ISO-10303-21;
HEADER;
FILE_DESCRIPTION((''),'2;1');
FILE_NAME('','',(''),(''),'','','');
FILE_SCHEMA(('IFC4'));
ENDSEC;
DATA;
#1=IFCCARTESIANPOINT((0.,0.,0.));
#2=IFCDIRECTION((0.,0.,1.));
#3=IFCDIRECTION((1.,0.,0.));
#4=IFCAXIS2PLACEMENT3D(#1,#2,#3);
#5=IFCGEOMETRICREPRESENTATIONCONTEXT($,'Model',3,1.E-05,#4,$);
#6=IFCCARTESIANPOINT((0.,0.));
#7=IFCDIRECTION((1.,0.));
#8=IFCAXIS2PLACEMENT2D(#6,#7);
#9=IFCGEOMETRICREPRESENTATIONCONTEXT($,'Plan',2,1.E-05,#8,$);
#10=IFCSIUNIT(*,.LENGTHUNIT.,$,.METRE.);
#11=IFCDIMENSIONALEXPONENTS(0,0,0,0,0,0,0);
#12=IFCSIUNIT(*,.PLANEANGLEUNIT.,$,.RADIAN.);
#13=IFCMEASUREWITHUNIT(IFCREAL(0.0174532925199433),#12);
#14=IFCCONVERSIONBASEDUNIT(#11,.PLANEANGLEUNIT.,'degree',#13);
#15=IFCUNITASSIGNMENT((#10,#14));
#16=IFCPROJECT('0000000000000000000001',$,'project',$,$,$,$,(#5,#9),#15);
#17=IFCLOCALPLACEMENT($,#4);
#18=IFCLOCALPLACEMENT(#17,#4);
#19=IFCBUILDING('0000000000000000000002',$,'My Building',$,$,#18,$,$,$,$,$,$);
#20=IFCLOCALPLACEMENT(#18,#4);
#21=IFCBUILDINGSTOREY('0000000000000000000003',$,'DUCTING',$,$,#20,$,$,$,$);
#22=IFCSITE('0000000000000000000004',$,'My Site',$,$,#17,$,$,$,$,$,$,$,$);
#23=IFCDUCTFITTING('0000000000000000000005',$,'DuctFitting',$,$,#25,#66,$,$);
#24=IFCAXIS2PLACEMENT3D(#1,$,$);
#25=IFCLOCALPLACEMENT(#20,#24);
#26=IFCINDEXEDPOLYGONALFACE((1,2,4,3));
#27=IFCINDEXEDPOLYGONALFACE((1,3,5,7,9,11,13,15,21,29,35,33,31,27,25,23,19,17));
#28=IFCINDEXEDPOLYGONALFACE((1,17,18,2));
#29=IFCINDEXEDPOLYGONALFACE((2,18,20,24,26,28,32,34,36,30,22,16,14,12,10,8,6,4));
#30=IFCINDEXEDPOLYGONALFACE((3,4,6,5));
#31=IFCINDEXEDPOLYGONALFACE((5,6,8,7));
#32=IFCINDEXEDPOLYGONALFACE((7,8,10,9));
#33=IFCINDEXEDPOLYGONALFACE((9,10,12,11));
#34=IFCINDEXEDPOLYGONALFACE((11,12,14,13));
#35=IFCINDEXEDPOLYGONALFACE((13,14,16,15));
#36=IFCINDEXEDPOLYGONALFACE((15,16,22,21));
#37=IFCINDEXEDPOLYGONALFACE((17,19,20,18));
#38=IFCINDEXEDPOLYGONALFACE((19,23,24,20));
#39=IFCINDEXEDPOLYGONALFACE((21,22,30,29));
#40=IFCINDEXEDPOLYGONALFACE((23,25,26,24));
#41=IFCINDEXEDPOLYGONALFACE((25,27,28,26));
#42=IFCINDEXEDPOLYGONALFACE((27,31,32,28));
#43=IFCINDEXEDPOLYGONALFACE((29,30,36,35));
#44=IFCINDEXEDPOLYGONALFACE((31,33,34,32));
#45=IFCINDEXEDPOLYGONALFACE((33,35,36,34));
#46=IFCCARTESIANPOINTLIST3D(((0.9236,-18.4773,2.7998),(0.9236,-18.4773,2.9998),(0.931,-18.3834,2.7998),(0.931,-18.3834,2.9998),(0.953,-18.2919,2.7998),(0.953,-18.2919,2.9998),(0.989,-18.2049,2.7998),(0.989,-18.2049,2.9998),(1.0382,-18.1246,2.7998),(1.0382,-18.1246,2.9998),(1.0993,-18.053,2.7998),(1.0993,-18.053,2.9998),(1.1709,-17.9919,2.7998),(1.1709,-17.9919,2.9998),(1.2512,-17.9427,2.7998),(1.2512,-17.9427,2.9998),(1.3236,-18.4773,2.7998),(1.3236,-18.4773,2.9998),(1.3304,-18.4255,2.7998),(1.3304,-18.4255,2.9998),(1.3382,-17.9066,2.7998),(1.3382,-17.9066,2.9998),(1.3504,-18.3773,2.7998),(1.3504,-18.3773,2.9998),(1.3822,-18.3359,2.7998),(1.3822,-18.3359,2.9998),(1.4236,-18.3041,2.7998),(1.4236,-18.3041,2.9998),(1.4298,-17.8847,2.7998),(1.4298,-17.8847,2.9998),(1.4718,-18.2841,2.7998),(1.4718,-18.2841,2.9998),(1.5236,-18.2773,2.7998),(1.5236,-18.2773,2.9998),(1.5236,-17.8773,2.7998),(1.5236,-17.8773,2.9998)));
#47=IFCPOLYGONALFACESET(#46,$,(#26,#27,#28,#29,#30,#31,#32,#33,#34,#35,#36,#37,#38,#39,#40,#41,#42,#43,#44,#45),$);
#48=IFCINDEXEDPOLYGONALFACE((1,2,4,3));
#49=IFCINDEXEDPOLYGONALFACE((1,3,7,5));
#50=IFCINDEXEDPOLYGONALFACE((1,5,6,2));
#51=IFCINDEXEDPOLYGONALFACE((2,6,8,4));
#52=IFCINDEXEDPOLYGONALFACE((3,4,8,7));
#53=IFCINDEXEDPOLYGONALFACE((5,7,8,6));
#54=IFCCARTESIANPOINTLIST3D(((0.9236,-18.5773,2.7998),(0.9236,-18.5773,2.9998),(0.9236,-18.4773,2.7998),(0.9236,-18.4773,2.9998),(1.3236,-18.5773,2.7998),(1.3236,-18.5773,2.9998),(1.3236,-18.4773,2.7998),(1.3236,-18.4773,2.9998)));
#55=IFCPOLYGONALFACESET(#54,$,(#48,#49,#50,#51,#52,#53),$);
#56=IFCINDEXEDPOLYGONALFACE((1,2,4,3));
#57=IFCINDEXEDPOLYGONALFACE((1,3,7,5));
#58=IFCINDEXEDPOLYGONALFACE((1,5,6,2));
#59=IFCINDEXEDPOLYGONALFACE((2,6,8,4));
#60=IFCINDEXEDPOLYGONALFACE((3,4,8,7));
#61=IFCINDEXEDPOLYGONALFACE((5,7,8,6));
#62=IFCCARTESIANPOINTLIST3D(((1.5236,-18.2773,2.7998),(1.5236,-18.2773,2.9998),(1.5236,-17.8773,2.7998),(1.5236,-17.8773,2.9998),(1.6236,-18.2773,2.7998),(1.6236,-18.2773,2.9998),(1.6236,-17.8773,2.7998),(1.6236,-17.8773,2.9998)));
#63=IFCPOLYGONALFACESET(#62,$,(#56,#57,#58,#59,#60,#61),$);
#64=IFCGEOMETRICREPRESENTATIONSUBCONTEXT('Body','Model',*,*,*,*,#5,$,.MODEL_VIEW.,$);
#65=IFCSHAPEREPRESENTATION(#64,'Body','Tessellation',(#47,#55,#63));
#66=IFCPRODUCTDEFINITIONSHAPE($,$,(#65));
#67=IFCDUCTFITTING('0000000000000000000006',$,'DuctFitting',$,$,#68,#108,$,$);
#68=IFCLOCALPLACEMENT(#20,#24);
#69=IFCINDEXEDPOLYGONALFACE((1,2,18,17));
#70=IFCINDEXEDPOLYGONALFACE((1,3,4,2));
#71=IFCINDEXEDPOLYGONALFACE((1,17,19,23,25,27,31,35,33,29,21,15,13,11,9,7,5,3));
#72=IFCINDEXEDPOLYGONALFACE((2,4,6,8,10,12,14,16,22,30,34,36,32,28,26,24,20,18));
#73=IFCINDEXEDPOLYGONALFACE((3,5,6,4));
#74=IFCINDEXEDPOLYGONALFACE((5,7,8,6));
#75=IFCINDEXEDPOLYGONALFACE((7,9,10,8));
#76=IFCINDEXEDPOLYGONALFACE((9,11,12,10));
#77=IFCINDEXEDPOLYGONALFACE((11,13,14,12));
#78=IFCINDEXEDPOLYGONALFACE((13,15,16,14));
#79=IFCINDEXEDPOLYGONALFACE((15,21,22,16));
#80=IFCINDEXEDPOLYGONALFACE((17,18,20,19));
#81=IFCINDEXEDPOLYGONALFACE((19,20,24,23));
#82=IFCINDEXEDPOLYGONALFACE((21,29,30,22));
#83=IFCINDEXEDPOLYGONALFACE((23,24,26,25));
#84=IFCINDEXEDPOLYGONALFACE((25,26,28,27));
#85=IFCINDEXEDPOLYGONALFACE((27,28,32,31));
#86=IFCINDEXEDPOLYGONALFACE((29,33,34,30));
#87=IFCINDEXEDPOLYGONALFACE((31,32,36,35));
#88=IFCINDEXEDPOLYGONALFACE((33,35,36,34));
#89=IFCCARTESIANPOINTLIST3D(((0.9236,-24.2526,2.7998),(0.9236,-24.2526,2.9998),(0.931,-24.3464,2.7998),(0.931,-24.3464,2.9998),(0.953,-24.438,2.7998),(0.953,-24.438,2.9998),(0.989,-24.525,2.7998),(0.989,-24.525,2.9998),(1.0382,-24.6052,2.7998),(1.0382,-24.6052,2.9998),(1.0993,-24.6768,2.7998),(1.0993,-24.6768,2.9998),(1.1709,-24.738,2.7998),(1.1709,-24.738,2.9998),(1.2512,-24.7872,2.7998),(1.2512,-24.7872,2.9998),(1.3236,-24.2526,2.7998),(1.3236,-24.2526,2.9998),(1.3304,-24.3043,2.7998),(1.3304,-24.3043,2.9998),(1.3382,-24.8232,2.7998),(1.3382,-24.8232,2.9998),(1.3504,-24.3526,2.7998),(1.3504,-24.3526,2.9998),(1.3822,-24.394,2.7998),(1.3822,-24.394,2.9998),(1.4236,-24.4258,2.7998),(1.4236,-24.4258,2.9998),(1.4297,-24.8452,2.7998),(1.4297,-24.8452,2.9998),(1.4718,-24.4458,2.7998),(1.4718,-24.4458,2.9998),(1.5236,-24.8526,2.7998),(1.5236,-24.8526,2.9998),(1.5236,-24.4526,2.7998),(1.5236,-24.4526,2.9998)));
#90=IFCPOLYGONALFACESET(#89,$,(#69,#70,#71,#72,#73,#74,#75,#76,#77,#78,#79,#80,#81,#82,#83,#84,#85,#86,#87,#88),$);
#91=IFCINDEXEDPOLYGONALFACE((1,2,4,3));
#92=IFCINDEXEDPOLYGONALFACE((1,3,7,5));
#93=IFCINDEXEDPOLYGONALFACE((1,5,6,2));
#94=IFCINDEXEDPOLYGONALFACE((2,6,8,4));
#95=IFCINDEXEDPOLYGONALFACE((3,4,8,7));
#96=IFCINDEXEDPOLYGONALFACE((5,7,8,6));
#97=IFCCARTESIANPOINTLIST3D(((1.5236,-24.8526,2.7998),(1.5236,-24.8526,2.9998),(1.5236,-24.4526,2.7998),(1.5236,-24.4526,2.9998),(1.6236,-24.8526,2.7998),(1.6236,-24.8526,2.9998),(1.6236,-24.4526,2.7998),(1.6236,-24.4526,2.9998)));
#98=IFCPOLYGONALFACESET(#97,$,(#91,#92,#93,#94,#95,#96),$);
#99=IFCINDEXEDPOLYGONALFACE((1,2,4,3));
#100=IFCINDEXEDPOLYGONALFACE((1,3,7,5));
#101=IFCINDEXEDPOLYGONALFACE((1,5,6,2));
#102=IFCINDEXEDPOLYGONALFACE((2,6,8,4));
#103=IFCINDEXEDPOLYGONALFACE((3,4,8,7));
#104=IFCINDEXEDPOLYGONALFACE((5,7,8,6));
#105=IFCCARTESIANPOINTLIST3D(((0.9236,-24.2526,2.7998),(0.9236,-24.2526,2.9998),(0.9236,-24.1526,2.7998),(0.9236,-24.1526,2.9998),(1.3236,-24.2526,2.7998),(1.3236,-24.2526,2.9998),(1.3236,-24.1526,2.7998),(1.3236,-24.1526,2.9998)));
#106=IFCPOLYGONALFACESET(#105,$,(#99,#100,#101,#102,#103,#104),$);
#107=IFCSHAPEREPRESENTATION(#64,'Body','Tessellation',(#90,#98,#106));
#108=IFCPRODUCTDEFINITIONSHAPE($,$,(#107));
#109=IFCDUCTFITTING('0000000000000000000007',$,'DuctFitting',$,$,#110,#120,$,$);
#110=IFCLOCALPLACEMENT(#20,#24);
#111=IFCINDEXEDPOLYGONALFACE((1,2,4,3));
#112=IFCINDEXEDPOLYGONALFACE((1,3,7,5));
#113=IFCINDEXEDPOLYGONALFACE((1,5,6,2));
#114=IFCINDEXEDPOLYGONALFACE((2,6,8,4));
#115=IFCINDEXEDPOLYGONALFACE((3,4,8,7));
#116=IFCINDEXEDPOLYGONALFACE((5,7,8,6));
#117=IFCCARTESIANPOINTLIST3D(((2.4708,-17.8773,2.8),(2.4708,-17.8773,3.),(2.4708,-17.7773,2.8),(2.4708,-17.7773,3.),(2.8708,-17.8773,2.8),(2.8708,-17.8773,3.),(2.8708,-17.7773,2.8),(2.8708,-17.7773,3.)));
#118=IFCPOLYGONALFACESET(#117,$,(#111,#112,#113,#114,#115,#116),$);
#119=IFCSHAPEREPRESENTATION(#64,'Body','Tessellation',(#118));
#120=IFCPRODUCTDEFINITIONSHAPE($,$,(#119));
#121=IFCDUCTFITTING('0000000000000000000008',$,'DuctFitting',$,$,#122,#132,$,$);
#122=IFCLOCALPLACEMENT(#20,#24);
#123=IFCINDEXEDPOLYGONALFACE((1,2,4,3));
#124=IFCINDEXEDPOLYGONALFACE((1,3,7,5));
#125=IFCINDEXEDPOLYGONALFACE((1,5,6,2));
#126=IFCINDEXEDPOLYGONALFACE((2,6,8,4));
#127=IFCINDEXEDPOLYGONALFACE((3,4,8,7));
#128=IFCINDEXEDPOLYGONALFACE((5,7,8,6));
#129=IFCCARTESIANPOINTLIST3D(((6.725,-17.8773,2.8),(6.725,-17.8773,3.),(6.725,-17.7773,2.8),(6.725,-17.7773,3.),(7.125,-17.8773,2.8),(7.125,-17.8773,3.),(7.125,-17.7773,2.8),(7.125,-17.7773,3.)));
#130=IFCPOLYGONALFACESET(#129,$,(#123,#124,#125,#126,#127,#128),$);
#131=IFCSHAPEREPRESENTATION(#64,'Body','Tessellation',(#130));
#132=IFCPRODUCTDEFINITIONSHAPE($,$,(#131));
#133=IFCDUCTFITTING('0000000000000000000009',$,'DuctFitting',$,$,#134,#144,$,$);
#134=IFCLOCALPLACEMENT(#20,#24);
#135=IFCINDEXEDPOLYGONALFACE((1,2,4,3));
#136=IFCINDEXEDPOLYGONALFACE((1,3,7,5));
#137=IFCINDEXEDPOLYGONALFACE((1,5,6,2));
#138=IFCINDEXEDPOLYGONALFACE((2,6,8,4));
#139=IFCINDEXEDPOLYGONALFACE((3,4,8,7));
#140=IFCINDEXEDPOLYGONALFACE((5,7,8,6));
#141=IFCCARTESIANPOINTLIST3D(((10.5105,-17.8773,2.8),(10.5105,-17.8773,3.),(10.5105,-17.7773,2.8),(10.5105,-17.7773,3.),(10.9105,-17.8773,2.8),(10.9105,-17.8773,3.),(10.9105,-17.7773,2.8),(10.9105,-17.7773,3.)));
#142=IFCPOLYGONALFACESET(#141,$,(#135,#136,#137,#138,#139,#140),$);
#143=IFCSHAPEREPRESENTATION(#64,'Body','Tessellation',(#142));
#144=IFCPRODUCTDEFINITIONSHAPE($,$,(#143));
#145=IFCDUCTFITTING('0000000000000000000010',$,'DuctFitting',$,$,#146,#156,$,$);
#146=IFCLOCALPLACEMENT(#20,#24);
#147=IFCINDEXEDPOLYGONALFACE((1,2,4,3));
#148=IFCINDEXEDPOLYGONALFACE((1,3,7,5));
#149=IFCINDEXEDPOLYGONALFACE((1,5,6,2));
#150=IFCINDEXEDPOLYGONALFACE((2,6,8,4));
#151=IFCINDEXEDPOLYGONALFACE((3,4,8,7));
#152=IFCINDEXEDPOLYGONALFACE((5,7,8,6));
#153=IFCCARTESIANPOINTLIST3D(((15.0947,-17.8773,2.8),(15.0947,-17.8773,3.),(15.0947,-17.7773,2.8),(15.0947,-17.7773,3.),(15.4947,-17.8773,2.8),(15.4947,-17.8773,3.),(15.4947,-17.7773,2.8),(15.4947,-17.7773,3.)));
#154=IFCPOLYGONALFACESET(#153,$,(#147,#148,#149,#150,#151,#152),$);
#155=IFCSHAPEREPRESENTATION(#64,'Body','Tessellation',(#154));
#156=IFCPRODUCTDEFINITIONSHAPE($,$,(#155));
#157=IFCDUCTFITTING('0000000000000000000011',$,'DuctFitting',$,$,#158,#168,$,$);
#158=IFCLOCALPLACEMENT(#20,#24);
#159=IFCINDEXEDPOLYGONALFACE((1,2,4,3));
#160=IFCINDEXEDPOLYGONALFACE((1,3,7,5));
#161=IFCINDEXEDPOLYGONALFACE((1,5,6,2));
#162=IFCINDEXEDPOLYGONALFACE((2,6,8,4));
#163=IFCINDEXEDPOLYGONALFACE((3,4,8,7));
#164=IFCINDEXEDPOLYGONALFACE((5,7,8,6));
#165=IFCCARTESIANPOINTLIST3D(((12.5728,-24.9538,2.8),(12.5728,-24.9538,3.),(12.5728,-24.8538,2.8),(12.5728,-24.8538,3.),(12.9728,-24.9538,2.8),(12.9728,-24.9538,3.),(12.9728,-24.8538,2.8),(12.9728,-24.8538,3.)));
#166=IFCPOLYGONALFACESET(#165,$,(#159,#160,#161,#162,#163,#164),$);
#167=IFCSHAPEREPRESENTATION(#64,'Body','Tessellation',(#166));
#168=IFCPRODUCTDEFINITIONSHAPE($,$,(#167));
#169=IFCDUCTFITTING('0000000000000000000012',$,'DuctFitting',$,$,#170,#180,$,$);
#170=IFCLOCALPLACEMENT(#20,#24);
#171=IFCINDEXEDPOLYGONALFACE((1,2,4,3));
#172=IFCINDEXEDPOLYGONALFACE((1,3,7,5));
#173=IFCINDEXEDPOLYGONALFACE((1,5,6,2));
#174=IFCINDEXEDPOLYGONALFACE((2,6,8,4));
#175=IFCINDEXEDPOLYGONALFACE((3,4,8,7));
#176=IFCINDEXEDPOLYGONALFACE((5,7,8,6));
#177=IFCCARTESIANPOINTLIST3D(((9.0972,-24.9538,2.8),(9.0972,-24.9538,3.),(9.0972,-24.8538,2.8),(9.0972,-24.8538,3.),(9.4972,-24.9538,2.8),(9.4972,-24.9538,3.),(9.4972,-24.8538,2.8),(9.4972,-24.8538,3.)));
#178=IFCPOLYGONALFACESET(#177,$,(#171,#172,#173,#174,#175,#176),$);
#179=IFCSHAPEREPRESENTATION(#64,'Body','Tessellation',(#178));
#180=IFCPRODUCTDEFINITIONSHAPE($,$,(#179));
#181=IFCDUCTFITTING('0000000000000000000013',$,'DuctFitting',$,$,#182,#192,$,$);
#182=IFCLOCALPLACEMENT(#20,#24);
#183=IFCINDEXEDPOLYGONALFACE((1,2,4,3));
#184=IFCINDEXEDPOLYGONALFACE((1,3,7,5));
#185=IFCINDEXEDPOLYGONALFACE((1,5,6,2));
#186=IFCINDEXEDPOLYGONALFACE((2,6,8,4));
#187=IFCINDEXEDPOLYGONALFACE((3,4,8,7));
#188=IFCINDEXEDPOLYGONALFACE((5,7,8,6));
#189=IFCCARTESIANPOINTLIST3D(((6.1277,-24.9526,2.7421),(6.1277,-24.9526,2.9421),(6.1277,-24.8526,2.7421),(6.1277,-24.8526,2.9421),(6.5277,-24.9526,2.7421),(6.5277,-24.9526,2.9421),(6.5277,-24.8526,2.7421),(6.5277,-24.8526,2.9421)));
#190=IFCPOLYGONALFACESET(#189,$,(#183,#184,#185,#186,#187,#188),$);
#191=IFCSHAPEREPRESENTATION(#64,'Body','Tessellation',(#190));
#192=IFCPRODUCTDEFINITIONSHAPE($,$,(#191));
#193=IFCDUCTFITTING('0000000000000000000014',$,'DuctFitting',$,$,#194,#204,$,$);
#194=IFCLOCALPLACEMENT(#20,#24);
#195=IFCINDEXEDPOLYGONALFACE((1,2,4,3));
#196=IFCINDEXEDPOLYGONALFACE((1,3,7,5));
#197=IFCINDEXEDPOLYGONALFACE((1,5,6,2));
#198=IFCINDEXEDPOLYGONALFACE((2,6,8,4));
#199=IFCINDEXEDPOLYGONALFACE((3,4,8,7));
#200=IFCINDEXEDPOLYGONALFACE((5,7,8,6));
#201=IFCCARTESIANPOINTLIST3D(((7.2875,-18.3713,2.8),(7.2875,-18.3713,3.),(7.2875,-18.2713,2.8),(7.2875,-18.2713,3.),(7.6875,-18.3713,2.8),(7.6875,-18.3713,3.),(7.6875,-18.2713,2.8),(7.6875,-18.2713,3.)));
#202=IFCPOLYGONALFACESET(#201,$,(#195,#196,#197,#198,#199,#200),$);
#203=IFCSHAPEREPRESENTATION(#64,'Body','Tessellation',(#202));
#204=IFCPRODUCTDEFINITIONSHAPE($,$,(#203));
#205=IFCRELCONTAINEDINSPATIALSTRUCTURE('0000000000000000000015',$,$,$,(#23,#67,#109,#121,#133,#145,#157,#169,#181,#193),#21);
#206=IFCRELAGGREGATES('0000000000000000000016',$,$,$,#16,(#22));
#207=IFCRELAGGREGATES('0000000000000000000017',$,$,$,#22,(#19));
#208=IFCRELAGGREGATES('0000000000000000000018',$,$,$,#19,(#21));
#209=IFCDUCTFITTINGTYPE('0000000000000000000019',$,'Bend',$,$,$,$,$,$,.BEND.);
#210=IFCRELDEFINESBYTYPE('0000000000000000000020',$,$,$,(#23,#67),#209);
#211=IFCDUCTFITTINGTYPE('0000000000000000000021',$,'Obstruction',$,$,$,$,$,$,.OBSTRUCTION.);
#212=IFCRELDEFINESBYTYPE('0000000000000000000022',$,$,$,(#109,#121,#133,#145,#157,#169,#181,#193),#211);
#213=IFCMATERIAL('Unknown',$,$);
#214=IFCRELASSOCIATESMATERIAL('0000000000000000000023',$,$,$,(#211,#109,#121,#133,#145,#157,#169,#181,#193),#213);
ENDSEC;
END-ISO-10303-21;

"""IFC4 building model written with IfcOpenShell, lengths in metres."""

from ifc_helpers import new_model, entity, si_unit, converted_unit, frame, origin_with_axes, origin_2d_with_axis, place, context, subcontext, project, spatial, line, arc, indexed_curve, rectangle, outline, extrude, source, transform, mapped, material, material_profile, profile_set, profile_usage, type_object, type_shapes, element, save


model = new_model("IFC4")

# Units and contexts
model_context = context("Model", 3, precision=1e-05, world=origin_with_axes())
plan_context = context("Plan", 2, precision=1e-05, world=origin_2d_with_axis())
body_context = subcontext(model_context, "Body", "Model", "MODEL_VIEW")
ifc_project = project(units=[si_unit("LENGTHUNIT", "METRE"), converted_unit("PLANEANGLEUNIT", "degree", entity("IfcReal", 0.0174532925199433), si_unit("PLANEANGLEUNIT", "RADIAN"), dimensions=[0, 0, 0, 0, 0, 0, 0])], contexts=[model_context, plan_context])

# Site, building, storey
site_placement = place(None, origin_with_axes())
site = spatial("IfcSite", under=ifc_project, at=site_placement, Name="My Site")
building_placement = place(site_placement, origin_with_axes())
building = spatial("IfcBuilding", under=site, at=building_placement, Name="My Building")
storey_placement = place(building_placement, origin_with_axes())
storey = spatial("IfcBuildingStorey", under=building, at=storey_placement, Name="DUCTING")

# Shared definitions
ifc_material = material(Name="Unknown")

# Duct fittings
duct_fitting_type_1 = type_object("IfcDuctFittingType", Name="Bend", PredefinedType="BEND")
shared_shape = source(origin_with_axes(), body_context, "Body", "SweptSolid", [
    extrude(outline(indexed_curve([(-0.2, 0.0), (-0.2586, 0.1414), (-0.4, 0.2), (-0.4, 0.6), (0.0243, 0.4243), (0.2, 0.0)], segments=[arc(1, 2, 3), line(3, 4), arc(4, 5, 6), line(6, 1)])), frame((0.0, -0.1, 0.1), z_axis=(0.0, -1.0, 0.0), x_axis=(1.0, 0.0, 0.0)), (0.0, 0.0, -1.0), 0.2),
    extrude(rectangle(XDim=0.4, YDim=0.2), origin_with_axes(), (0.0, 0.0, 1.0), 0.1),
    extrude(rectangle(XDim=0.4, YDim=0.2), frame((-0.4, 0.0, 0.5), z_axis=(-1.0, 0.0, 0.0), x_axis=(0.0, 0.0, -1.0)), (0.0, 0.0, 1.0), 0.1),
])
type_shapes(duct_fitting_type_1, [shared_shape])
for number, where, z_axis, x_axis, name in (
    (1, (1.1236, -18.5773, 2.8998), (0.0, 1.0, 0.0), (-1.0, 0.0, 0.0), "DuctFitting"),
    (2, (1.6236, -24.6526, 2.8998), (-1.0, 0.0, 0.0), (0.0, -1.0, 0.0), "DuctFitting"),
):
    element("IfcDuctFitting", number, at=place(storey_placement, frame(where, z_axis=z_axis, x_axis=x_axis)), inside=storey, type_object=duct_fitting_type_1, Name=name, context=body_context, shape_type="MappedRepresentation", body=[
        mapped(shared_shape, transform((0.0, 0.0, 0.0), x_axis=(1.0, 0.0, 0.0), y_axis=(0.0, 1.0, 0.0), z_axis=(0.0, 0.0, 1.0), scale=1.0)),
    ])
ifc_material_profile_1 = material_profile(ifc_material, rectangle(XDim=0.4, YDim=0.2))
ifc_profile_set_1 = profile_set([ifc_material_profile_1])
ifc_profile_usage_1 = profile_usage(ifc_profile_set_1, cardinal=5)
duct_fitting_type_2 = type_object("IfcDuctFittingType", Name="Obstruction", PredefinedType="OBSTRUCTION", material=ifc_profile_set_1)
duct_fitting_1_placement = place(storey_placement, frame((2.6708, -17.8773, 2.9), z_axis=(0.0, 1.0, 0.0), x_axis=(-1.0, 0.0, 0.0)))
element("IfcDuctFitting", 3, at=duct_fitting_1_placement, inside=storey, type_object=duct_fitting_type_2, material=ifc_profile_usage_1, Name="DuctFitting", context=body_context, shape_type="SweptSolid", body=[
    extrude(rectangle(XDim=0.4, YDim=0.2), origin_with_axes(), (0.0, 0.0, 1.0), 0.1),
])
ifc_profile_usage_2 = profile_usage(ifc_profile_set_1, cardinal=5)
duct_fitting_2_placement = place(storey_placement, frame((6.925, -17.8773, 2.9), z_axis=(0.0, 1.0, 0.0), x_axis=(-1.0, 0.0, 0.0)))
element("IfcDuctFitting", 4, at=duct_fitting_2_placement, inside=storey, type_object=duct_fitting_type_2, material=ifc_profile_usage_2, Name="DuctFitting", context=body_context, shape_type="SweptSolid", body=[
    extrude(rectangle(XDim=0.4, YDim=0.2), origin_with_axes(), (0.0, 0.0, 1.0), 0.1),
])
ifc_profile_usage_3 = profile_usage(ifc_profile_set_1, cardinal=5)
duct_fitting_3_placement = place(storey_placement, frame((10.7105, -17.8773, 2.9), z_axis=(0.0, 1.0, 0.0), x_axis=(-1.0, 0.0, 0.0)))
element("IfcDuctFitting", 5, at=duct_fitting_3_placement, inside=storey, type_object=duct_fitting_type_2, material=ifc_profile_usage_3, Name="DuctFitting", context=body_context, shape_type="SweptSolid", body=[
    extrude(rectangle(XDim=0.4, YDim=0.2), origin_with_axes(), (0.0, 0.0, 1.0), 0.1),
])
ifc_profile_usage_4 = profile_usage(ifc_profile_set_1, cardinal=5)
duct_fitting_4_placement = place(storey_placement, frame((15.2947, -17.8773, 2.9), z_axis=(0.0, 1.0, 0.0), x_axis=(-1.0, 0.0, 0.0)))
element("IfcDuctFitting", 6, at=duct_fitting_4_placement, inside=storey, type_object=duct_fitting_type_2, material=ifc_profile_usage_4, Name="DuctFitting", context=body_context, shape_type="SweptSolid", body=[
    extrude(rectangle(XDim=0.4, YDim=0.2), origin_with_axes(), (0.0, 0.0, 1.0), 0.1),
])
ifc_profile_usage_5 = profile_usage(ifc_profile_set_1, cardinal=5)
duct_fitting_5_placement = place(storey_placement, frame((12.7728, -24.8538, 2.9), z_axis=(0.0, -1.0, 0.0), x_axis=(1.0, 0.0, 0.0)))
element("IfcDuctFitting", 7, at=duct_fitting_5_placement, inside=storey, type_object=duct_fitting_type_2, material=ifc_profile_usage_5, Name="DuctFitting", context=body_context, shape_type="SweptSolid", body=[
    extrude(rectangle(XDim=0.4, YDim=0.2), origin_with_axes(), (0.0, 0.0, 1.0), 0.1),
])
ifc_profile_usage_6 = profile_usage(ifc_profile_set_1, cardinal=5)
duct_fitting_6_placement = place(storey_placement, frame((9.2972, -24.8538, 2.9), z_axis=(0.0, -1.0, 0.0), x_axis=(1.0, 0.0, 0.0)))
element("IfcDuctFitting", 8, at=duct_fitting_6_placement, inside=storey, type_object=duct_fitting_type_2, material=ifc_profile_usage_6, Name="DuctFitting", context=body_context, shape_type="SweptSolid", body=[
    extrude(rectangle(XDim=0.4, YDim=0.2), origin_with_axes(), (0.0, 0.0, 1.0), 0.1),
])
ifc_profile_usage_7 = profile_usage(ifc_profile_set_1, cardinal=5)
duct_fitting_7_placement = place(storey_placement, frame((6.3277, -24.8526, 2.8421), z_axis=(0.0, -1.0, 0.0), x_axis=(1.0, 0.0, 0.0)))
element("IfcDuctFitting", 9, at=duct_fitting_7_placement, inside=storey, type_object=duct_fitting_type_2, material=ifc_profile_usage_7, Name="DuctFitting", context=body_context, shape_type="SweptSolid", body=[
    extrude(rectangle(XDim=0.4, YDim=0.2), origin_with_axes(), (0.0, 0.0, 1.0), 0.1),
])
ifc_profile_usage_8 = profile_usage(ifc_profile_set_1, cardinal=5)
duct_fitting_8_placement = place(storey_placement, frame((7.4875, -18.2713, 2.9), z_axis=(0.0, -1.0, 0.0), x_axis=(1.0, 0.0, 0.0)))
element("IfcDuctFitting", 10, at=duct_fitting_8_placement, inside=storey, type_object=duct_fitting_type_2, material=ifc_profile_usage_8, Name="DuctFitting", context=body_context, shape_type="SweptSolid", body=[
    extrude(rectangle(XDim=0.4, YDim=0.2), origin_with_axes(), (0.0, 0.0, 1.0), 0.1),
])

save(model, "model.ifc")
